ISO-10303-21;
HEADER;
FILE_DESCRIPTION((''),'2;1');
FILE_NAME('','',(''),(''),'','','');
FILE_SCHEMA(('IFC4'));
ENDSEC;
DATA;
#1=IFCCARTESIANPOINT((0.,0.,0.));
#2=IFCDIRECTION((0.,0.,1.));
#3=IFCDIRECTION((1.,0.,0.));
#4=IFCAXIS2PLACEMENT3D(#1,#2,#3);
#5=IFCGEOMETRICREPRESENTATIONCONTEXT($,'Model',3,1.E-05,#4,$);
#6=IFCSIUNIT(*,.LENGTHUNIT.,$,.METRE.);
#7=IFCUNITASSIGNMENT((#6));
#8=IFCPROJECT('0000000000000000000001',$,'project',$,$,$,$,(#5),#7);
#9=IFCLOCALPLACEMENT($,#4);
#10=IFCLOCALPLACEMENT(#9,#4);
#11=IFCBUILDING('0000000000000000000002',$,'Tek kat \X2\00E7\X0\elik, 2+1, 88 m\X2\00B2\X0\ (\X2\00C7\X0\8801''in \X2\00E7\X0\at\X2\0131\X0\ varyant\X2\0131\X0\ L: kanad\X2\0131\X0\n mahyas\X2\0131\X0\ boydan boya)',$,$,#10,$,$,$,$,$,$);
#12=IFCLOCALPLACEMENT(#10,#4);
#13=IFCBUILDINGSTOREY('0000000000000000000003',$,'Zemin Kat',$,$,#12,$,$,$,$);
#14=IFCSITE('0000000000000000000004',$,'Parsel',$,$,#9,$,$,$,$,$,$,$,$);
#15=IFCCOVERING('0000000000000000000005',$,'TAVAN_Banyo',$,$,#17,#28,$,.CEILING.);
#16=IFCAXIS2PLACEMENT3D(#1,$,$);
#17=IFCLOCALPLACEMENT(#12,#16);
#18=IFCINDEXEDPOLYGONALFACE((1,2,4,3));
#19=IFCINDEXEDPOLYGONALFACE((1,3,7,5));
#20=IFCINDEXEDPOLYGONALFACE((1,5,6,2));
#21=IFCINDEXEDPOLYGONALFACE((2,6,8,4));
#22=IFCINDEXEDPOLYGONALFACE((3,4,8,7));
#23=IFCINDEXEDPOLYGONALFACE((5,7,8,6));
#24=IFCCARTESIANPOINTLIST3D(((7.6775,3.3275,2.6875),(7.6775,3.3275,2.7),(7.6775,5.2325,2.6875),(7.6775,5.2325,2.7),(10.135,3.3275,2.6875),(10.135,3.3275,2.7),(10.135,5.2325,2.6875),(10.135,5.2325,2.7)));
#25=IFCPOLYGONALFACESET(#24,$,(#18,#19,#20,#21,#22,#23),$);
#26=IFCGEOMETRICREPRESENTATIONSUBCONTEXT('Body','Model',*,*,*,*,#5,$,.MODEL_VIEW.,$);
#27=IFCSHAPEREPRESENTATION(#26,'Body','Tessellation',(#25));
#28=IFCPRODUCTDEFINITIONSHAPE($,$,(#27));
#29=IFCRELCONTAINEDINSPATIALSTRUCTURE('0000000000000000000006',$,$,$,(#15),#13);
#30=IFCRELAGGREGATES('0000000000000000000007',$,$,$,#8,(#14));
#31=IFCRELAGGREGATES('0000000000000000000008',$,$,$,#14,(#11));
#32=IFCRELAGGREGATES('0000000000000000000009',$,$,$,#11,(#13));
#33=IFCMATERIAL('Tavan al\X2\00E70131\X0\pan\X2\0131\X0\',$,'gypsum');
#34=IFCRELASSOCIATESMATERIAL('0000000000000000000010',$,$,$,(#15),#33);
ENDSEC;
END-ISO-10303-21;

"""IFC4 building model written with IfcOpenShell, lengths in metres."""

from ifc_helpers import new_model, si_unit, frame, origin_with_axes, place, context, subcontext, project, spatial, line, indexed_curve, outline, extrude, material, element, save


model = new_model("IFC4")

# Units and contexts
model_context = context("Model", 3, precision=1e-05, world=origin_with_axes())
body_context = subcontext(model_context, "Body", "Model", "MODEL_VIEW")
ifc_project = project(units=[si_unit("LENGTHUNIT", "METRE")], contexts=[model_context])

# Site, building, storey
site_placement = place(None, origin_with_axes())
site = spatial("IfcSite", under=ifc_project, at=site_placement, Name="Parsel")
building_placement = place(site_placement, origin_with_axes())
building = spatial("IfcBuilding", under=site, at=building_placement, Name="Tek kat çelik, 2+1, 88 m² (Ç8801'in çatı varyantı L: kanadın mahyası boydan boya)")
storey_placement = place(building_placement, origin_with_axes())
storey = spatial("IfcBuildingStorey", under=building, at=storey_placement, Name="Zemin Kat")

# Covering
ifc_material_1 = material(Name="Tavan alçıpanı", Category="gypsum")
covering_1_placement = place(storey_placement, origin_with_axes())
element("IfcCovering", 1, at=covering_1_placement, inside=storey, material=ifc_material_1, Name="TAVAN_Banyo", PredefinedType="CEILING", context=body_context, shape_type="SweptSolid", body=[
    extrude(outline(indexed_curve([(7.6775, 5.2325), (10.135, 5.2325), (10.135, 3.3275), (7.6775, 3.3275)], segments=[line(1, 2, 3, 4, 1)])), frame((0.0, 0.0, 2.6875), z_axis=(0.0, 0.0, 1.0), x_axis=(1.0, 0.0, 0.0)), (0.0, 0.0, 1.0), 0.0125),
])

save(model, "model.ifc")
